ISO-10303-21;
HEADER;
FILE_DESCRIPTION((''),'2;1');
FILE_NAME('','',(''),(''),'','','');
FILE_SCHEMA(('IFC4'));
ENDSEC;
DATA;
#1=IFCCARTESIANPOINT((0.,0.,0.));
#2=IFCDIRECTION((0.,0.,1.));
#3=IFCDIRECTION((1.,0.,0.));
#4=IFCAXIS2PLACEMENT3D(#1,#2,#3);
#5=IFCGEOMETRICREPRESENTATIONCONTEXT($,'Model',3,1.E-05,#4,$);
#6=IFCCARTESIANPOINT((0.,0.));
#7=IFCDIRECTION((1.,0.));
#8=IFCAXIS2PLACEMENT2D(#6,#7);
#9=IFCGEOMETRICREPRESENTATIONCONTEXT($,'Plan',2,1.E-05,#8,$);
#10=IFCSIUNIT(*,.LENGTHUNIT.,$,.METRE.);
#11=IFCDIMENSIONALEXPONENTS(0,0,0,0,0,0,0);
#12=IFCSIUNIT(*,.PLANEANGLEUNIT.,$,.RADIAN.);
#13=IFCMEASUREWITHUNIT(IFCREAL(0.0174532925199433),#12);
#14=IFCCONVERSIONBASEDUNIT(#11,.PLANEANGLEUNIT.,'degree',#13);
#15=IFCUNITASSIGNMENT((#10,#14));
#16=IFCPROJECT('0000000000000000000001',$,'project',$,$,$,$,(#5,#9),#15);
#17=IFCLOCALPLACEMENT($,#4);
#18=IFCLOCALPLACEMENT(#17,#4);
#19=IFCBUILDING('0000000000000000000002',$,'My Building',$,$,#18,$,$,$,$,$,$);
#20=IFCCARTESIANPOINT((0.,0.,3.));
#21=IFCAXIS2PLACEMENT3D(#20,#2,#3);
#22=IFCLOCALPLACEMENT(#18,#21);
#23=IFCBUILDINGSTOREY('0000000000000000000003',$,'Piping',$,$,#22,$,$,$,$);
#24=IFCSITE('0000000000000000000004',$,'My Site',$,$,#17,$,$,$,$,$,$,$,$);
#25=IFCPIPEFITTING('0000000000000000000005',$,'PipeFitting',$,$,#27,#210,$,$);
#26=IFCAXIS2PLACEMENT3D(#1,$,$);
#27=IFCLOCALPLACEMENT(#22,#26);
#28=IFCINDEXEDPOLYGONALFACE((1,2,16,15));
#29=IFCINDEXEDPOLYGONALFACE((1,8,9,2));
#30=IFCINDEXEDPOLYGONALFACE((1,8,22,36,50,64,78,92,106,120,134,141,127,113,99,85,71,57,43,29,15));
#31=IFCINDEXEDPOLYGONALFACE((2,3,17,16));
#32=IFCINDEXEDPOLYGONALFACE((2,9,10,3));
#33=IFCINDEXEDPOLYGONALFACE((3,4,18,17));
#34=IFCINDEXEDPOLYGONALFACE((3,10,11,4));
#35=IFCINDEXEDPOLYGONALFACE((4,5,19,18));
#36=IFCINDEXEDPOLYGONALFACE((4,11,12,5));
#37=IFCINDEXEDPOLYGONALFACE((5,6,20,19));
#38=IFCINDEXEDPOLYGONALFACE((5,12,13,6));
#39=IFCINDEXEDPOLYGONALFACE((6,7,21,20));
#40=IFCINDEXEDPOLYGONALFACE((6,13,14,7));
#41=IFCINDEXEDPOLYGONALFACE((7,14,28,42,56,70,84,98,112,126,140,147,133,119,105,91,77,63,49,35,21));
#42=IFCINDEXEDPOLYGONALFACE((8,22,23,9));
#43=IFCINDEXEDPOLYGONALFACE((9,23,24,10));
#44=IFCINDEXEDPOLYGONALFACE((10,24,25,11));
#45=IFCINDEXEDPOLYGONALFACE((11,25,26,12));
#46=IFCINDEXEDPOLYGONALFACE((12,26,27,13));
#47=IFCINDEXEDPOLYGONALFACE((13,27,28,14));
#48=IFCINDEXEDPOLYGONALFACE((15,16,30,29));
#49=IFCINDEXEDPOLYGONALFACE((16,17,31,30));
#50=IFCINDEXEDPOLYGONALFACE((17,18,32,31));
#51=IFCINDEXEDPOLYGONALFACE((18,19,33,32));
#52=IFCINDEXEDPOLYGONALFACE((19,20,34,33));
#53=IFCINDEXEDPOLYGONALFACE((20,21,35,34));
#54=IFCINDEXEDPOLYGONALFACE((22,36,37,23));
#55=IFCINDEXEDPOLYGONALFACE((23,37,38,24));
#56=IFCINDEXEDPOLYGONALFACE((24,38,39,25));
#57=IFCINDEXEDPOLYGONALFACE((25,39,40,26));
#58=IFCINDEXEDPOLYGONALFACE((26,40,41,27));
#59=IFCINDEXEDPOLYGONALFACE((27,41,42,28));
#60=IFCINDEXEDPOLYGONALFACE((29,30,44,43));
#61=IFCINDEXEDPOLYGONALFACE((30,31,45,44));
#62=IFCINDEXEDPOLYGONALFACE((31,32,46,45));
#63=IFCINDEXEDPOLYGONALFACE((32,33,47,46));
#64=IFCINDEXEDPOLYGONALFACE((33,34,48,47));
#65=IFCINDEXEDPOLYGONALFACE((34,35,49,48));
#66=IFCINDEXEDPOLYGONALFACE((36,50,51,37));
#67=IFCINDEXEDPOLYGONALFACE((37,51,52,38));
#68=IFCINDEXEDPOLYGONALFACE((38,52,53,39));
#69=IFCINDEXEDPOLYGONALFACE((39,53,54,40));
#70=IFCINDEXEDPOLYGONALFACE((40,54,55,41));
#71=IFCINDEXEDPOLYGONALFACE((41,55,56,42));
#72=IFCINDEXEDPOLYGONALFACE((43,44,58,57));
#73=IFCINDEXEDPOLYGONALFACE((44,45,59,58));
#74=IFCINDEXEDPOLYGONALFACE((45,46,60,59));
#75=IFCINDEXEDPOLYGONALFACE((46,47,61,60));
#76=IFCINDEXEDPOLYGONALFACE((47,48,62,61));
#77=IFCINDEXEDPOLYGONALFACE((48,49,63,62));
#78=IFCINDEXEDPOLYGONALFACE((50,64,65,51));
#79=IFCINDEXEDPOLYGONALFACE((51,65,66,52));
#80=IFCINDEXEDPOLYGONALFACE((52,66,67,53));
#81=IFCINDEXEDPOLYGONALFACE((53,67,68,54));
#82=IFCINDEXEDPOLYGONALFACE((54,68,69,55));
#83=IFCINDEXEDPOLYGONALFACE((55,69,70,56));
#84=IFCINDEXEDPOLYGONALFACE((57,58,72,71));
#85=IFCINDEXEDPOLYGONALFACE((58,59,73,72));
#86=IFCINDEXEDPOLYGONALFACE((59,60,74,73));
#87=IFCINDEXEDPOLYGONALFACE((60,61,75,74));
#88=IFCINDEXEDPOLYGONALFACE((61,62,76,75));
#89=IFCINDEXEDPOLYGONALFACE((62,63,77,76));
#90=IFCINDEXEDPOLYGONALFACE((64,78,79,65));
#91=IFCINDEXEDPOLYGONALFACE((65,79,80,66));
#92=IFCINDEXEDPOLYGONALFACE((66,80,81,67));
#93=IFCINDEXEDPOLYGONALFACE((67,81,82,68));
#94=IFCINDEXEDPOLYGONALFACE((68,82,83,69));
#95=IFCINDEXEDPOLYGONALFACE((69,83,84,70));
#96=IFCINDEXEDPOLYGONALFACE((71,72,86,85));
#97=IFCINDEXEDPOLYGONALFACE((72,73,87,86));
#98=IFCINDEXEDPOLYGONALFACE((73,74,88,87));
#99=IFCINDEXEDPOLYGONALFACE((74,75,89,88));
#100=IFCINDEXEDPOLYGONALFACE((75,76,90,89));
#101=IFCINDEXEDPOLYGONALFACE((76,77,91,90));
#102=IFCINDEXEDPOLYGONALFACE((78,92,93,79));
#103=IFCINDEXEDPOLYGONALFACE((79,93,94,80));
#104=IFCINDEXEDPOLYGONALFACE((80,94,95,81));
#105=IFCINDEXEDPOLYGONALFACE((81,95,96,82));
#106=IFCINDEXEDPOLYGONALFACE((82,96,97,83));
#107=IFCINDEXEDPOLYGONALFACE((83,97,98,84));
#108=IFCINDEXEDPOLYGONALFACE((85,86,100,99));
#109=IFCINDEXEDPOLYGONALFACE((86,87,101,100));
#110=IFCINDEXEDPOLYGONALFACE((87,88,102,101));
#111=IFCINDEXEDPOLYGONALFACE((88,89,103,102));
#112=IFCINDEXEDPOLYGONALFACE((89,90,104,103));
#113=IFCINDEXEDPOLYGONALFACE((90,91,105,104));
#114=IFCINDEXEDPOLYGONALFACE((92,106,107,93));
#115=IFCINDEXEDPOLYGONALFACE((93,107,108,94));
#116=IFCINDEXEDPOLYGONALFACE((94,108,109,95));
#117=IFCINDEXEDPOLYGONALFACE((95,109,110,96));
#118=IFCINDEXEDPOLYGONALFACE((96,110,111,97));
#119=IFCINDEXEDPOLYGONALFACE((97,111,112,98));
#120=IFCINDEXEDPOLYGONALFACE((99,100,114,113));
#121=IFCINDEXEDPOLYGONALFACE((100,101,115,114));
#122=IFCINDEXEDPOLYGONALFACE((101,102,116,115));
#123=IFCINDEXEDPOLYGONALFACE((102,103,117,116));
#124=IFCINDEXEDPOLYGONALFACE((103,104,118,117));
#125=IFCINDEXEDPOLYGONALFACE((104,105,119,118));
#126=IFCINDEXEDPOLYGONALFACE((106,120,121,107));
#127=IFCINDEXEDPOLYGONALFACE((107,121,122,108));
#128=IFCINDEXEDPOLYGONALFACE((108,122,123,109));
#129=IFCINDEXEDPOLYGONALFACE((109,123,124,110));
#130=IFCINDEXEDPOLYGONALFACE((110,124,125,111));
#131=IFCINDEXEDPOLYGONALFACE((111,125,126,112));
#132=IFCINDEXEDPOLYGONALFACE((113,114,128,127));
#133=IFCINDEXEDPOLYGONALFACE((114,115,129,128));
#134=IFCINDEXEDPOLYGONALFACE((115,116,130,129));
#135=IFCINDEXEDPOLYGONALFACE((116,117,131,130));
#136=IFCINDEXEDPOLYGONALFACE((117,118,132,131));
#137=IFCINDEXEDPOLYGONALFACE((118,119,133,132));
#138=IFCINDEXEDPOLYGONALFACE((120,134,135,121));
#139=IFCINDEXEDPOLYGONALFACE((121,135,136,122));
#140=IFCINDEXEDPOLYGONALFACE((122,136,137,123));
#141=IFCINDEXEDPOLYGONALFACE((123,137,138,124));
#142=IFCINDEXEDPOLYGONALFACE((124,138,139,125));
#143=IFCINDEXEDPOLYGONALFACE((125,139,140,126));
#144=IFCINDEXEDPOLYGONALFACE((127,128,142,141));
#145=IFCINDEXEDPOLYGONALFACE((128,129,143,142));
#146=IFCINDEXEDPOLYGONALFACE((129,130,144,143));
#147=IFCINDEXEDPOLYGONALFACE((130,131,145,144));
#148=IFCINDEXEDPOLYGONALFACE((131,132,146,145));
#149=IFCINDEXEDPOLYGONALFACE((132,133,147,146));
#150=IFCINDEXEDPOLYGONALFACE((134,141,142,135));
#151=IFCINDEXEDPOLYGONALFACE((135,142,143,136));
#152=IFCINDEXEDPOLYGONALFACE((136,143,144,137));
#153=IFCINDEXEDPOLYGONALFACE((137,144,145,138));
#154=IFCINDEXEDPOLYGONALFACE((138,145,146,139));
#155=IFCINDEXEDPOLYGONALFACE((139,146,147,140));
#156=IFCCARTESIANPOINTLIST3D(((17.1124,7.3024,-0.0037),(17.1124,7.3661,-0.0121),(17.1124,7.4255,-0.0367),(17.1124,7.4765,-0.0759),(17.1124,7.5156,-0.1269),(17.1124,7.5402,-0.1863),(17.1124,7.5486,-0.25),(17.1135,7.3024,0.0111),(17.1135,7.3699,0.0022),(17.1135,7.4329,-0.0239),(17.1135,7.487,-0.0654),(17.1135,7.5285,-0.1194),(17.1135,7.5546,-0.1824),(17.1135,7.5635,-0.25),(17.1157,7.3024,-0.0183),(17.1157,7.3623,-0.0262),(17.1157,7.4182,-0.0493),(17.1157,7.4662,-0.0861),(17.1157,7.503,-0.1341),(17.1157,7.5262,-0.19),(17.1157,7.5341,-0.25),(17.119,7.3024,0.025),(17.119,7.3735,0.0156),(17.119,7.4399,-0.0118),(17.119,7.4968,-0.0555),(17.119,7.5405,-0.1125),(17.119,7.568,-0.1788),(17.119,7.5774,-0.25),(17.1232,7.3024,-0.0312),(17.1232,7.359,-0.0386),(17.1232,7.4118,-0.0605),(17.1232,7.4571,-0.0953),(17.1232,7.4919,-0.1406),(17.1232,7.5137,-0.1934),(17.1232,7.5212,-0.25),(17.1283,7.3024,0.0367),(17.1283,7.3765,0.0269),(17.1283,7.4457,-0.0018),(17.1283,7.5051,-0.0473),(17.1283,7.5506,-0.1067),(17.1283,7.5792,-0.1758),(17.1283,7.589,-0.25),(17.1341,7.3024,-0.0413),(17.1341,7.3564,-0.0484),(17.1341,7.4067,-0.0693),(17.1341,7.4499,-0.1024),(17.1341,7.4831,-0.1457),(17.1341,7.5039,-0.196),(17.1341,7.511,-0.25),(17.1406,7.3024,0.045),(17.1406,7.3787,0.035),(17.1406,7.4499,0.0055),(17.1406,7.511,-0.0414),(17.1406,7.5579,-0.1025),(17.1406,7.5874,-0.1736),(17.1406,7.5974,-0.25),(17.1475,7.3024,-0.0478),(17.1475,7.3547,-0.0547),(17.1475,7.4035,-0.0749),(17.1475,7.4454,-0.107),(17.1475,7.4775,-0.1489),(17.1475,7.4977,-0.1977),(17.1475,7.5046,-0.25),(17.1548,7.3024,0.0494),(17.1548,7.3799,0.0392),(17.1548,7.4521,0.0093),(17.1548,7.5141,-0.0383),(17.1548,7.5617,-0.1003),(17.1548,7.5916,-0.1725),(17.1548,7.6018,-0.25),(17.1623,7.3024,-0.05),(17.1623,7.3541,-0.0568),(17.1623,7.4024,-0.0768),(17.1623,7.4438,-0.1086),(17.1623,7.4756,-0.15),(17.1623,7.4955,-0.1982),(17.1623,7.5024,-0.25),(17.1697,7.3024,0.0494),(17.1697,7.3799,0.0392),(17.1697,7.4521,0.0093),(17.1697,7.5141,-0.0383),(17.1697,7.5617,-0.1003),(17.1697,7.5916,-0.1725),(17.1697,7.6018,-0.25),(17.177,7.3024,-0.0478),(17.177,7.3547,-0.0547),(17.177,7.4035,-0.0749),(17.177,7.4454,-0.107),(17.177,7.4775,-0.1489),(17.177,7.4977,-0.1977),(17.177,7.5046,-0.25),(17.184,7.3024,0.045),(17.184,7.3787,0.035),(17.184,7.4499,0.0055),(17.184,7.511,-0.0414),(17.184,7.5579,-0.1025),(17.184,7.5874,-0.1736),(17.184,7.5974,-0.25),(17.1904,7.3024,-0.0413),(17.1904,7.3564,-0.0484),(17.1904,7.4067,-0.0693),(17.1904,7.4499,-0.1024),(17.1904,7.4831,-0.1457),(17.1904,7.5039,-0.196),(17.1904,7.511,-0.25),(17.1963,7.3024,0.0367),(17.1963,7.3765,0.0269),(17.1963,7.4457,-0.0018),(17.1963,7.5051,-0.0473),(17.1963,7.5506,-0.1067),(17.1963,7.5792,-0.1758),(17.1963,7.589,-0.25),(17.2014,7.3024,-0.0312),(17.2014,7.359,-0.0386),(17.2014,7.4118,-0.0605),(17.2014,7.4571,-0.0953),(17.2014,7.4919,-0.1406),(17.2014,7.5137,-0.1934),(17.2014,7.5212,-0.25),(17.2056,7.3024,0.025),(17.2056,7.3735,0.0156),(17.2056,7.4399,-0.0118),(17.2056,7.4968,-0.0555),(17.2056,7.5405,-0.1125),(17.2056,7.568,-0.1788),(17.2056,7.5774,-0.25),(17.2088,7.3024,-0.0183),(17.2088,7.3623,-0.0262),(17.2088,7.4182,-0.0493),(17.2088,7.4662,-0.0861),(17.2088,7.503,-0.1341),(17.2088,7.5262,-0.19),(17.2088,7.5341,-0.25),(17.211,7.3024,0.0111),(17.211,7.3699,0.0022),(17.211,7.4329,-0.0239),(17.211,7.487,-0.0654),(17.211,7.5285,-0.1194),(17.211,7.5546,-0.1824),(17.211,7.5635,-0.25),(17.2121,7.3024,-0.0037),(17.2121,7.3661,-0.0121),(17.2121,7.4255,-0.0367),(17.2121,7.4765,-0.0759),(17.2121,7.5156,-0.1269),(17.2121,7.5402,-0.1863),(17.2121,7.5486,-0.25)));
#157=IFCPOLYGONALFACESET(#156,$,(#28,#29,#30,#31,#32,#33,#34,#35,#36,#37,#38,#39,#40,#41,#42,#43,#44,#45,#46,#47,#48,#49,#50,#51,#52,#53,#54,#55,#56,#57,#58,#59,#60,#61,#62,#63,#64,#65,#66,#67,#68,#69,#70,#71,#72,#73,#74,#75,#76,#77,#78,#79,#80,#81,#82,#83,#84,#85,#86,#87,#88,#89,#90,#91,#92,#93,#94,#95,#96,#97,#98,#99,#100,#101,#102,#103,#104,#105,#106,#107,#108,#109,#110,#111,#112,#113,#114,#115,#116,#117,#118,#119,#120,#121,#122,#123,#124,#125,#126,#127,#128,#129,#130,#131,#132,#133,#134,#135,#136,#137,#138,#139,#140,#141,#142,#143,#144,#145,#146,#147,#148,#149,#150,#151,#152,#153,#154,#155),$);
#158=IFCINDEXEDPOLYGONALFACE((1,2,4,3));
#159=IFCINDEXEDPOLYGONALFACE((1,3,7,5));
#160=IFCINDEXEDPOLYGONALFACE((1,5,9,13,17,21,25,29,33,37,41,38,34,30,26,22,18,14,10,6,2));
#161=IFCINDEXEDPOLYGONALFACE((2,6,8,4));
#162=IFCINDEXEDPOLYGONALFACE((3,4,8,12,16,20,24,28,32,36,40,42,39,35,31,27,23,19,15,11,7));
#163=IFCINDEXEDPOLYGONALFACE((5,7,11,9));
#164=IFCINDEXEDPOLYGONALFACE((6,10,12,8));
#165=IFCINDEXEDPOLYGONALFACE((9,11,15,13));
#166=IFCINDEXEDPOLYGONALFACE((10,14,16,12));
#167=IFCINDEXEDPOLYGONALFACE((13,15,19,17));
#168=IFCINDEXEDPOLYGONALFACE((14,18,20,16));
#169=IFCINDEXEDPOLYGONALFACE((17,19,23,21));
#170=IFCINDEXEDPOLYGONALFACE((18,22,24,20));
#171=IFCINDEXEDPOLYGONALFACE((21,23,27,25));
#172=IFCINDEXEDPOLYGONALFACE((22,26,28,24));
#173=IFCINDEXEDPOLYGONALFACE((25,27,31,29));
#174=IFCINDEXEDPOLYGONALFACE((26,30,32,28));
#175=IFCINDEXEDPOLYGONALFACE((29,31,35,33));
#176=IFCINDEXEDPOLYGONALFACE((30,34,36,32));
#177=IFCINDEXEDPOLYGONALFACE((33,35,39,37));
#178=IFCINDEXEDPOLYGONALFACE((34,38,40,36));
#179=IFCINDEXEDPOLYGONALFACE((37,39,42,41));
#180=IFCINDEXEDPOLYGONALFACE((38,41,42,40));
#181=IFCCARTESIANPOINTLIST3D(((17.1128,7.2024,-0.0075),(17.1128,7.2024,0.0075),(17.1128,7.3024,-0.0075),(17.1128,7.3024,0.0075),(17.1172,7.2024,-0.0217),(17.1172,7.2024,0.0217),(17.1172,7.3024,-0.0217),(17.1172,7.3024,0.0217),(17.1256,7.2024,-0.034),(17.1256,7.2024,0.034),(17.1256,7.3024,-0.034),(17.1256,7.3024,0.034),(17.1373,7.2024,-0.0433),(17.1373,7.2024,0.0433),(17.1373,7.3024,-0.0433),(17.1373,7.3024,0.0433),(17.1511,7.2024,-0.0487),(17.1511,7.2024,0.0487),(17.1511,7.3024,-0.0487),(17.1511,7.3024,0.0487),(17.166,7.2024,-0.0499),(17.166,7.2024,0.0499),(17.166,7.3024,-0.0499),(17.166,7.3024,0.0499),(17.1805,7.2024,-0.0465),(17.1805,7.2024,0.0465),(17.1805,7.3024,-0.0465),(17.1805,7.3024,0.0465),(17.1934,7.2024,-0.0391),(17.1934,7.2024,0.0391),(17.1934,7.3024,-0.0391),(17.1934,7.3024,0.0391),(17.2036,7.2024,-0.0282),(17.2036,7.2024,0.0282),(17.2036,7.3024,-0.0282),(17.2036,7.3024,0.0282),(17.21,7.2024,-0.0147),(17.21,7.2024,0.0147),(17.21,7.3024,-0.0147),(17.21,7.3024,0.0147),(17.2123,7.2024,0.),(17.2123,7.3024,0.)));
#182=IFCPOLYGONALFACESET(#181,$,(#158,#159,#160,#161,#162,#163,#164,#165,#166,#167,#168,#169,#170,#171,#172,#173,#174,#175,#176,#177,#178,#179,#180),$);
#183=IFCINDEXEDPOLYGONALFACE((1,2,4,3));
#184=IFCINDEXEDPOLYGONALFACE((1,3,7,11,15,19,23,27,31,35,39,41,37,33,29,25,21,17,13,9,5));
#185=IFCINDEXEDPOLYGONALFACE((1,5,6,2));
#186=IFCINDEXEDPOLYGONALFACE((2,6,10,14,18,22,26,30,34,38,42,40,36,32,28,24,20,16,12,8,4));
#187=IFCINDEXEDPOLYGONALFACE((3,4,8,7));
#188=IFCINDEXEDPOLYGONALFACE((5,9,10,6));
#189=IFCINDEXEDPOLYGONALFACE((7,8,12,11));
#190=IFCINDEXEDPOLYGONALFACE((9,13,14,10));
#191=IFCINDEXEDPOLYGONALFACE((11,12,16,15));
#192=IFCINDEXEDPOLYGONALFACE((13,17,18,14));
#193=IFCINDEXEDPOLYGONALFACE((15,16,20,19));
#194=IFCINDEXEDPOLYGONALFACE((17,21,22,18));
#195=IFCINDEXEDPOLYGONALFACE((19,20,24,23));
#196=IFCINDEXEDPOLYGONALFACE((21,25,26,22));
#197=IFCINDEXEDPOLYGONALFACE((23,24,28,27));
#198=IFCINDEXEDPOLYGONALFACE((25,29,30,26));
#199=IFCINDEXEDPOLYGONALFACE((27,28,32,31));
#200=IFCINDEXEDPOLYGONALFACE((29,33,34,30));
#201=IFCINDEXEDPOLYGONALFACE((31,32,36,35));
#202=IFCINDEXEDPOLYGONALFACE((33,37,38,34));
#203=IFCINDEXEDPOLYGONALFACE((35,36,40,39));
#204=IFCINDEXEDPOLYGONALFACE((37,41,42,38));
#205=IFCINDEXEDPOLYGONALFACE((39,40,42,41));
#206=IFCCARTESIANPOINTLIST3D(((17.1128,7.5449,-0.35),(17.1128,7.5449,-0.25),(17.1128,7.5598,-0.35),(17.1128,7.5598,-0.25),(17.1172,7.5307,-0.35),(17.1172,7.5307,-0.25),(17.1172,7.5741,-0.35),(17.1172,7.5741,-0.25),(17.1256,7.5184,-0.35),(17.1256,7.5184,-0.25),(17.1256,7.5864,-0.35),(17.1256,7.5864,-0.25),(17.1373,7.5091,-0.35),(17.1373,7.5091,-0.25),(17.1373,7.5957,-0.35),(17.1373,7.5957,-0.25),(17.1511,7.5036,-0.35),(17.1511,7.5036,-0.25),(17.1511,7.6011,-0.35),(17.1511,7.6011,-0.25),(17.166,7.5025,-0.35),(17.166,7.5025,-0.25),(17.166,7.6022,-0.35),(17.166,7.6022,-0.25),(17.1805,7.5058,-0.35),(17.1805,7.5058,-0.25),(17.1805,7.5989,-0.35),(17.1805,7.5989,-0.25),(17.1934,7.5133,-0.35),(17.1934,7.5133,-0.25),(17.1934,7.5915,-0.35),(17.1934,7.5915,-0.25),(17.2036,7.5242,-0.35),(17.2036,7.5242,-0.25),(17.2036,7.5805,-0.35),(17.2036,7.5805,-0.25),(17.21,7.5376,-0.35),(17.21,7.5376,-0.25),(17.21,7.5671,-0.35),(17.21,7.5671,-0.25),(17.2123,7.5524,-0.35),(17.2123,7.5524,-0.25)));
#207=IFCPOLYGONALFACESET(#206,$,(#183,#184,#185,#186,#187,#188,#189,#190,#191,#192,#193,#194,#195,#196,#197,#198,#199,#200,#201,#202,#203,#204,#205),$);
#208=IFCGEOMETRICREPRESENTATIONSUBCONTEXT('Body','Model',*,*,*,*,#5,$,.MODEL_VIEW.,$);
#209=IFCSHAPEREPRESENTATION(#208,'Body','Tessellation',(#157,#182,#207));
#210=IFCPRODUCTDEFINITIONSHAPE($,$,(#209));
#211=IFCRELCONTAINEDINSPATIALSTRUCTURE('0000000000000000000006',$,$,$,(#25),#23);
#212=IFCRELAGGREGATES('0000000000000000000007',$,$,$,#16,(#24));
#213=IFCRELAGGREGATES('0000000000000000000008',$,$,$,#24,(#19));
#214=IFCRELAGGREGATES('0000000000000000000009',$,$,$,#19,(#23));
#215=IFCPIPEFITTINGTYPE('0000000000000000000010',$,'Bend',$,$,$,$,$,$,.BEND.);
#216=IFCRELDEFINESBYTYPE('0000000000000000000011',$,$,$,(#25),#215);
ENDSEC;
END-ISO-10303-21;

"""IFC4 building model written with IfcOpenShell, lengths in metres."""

from ifc_helpers import new_model, entity, si_unit, converted_unit, frame, origin_with_axes, origin_2d_with_axis, place, context, subcontext, project, spatial, circle, extrude, source, transform, mapped, type_object, type_shapes, element, save


model = new_model("IFC4")

# Units and contexts
model_context = context("Model", 3, precision=1e-05, world=origin_with_axes())
plan_context = context("Plan", 2, precision=1e-05, world=origin_2d_with_axis())
body_context = subcontext(model_context, "Body", "Model", "MODEL_VIEW")
ifc_project = project(units=[si_unit("LENGTHUNIT", "METRE"), converted_unit("PLANEANGLEUNIT", "degree", entity("IfcReal", 0.0174532925199433), si_unit("PLANEANGLEUNIT", "RADIAN"), dimensions=[0, 0, 0, 0, 0, 0, 0])], contexts=[model_context, plan_context])

# Site, building, storey
site_placement = place(None, origin_with_axes())
site = spatial("IfcSite", under=ifc_project, at=site_placement, Name="My Site")
building_placement = place(site_placement, origin_with_axes())
building = spatial("IfcBuilding", under=site, at=building_placement, Name="My Building")
storey_placement = place(building_placement, frame((0.0, 0.0, 3.0), z_axis=(0.0, 0.0, 1.0), x_axis=(1.0, 0.0, 0.0)))
storey = spatial("IfcBuildingStorey", under=building, at=storey_placement, Name="Piping")

# Pipe fitting
pipe_fitting_type_1 = type_object("IfcPipeFittingType", Name="Bend", PredefinedType="BEND")
shared_shape = source(origin_with_axes(), body_context, "Body", "SolidModel", [
    entity("IfcSweptDiskSolid", entity("IfcIndexedPolyCurve", entity("IfcCartesianPointList3D", [[0.0, 0.0, -0.1], [0.0, -0.0732, -0.2768], [0.0, -0.25, -0.35]]), [entity("IfcArcIndex", [1, 2, 3])]), 0.05),
    extrude(circle(Radius=0.05), origin_with_axes(), (0.0, 0.0, -1.0), 0.1),
    extrude(circle(Radius=0.05), frame((0.0, -0.25, -0.35), z_axis=(0.0, -1.0, 0.0), x_axis=(1.0, 0.0, 0.0)), (0.0, 0.0, 1.0), 0.1),
])
type_shapes(pipe_fitting_type_1, [shared_shape])
for number, where, z_axis, x_axis, name in (
    (1, (17.1623, 7.2024, 0.0), (0.0, -1.0, 0.0), (1.0, 0.0, 0.0), "PipeFitting"),
):
    element("IfcPipeFitting", number, at=place(storey_placement, frame(where, z_axis=z_axis, x_axis=x_axis)), inside=storey, type_object=pipe_fitting_type_1, Name=name, context=body_context, shape_type="MappedRepresentation", body=[
        mapped(shared_shape, transform((0.0, 0.0, 0.0), x_axis=(1.0, 0.0, 0.0), y_axis=(0.0, 1.0, 0.0), z_axis=(0.0, 0.0, 1.0), scale=1.0)),
    ])

save(model, "model.ifc")
